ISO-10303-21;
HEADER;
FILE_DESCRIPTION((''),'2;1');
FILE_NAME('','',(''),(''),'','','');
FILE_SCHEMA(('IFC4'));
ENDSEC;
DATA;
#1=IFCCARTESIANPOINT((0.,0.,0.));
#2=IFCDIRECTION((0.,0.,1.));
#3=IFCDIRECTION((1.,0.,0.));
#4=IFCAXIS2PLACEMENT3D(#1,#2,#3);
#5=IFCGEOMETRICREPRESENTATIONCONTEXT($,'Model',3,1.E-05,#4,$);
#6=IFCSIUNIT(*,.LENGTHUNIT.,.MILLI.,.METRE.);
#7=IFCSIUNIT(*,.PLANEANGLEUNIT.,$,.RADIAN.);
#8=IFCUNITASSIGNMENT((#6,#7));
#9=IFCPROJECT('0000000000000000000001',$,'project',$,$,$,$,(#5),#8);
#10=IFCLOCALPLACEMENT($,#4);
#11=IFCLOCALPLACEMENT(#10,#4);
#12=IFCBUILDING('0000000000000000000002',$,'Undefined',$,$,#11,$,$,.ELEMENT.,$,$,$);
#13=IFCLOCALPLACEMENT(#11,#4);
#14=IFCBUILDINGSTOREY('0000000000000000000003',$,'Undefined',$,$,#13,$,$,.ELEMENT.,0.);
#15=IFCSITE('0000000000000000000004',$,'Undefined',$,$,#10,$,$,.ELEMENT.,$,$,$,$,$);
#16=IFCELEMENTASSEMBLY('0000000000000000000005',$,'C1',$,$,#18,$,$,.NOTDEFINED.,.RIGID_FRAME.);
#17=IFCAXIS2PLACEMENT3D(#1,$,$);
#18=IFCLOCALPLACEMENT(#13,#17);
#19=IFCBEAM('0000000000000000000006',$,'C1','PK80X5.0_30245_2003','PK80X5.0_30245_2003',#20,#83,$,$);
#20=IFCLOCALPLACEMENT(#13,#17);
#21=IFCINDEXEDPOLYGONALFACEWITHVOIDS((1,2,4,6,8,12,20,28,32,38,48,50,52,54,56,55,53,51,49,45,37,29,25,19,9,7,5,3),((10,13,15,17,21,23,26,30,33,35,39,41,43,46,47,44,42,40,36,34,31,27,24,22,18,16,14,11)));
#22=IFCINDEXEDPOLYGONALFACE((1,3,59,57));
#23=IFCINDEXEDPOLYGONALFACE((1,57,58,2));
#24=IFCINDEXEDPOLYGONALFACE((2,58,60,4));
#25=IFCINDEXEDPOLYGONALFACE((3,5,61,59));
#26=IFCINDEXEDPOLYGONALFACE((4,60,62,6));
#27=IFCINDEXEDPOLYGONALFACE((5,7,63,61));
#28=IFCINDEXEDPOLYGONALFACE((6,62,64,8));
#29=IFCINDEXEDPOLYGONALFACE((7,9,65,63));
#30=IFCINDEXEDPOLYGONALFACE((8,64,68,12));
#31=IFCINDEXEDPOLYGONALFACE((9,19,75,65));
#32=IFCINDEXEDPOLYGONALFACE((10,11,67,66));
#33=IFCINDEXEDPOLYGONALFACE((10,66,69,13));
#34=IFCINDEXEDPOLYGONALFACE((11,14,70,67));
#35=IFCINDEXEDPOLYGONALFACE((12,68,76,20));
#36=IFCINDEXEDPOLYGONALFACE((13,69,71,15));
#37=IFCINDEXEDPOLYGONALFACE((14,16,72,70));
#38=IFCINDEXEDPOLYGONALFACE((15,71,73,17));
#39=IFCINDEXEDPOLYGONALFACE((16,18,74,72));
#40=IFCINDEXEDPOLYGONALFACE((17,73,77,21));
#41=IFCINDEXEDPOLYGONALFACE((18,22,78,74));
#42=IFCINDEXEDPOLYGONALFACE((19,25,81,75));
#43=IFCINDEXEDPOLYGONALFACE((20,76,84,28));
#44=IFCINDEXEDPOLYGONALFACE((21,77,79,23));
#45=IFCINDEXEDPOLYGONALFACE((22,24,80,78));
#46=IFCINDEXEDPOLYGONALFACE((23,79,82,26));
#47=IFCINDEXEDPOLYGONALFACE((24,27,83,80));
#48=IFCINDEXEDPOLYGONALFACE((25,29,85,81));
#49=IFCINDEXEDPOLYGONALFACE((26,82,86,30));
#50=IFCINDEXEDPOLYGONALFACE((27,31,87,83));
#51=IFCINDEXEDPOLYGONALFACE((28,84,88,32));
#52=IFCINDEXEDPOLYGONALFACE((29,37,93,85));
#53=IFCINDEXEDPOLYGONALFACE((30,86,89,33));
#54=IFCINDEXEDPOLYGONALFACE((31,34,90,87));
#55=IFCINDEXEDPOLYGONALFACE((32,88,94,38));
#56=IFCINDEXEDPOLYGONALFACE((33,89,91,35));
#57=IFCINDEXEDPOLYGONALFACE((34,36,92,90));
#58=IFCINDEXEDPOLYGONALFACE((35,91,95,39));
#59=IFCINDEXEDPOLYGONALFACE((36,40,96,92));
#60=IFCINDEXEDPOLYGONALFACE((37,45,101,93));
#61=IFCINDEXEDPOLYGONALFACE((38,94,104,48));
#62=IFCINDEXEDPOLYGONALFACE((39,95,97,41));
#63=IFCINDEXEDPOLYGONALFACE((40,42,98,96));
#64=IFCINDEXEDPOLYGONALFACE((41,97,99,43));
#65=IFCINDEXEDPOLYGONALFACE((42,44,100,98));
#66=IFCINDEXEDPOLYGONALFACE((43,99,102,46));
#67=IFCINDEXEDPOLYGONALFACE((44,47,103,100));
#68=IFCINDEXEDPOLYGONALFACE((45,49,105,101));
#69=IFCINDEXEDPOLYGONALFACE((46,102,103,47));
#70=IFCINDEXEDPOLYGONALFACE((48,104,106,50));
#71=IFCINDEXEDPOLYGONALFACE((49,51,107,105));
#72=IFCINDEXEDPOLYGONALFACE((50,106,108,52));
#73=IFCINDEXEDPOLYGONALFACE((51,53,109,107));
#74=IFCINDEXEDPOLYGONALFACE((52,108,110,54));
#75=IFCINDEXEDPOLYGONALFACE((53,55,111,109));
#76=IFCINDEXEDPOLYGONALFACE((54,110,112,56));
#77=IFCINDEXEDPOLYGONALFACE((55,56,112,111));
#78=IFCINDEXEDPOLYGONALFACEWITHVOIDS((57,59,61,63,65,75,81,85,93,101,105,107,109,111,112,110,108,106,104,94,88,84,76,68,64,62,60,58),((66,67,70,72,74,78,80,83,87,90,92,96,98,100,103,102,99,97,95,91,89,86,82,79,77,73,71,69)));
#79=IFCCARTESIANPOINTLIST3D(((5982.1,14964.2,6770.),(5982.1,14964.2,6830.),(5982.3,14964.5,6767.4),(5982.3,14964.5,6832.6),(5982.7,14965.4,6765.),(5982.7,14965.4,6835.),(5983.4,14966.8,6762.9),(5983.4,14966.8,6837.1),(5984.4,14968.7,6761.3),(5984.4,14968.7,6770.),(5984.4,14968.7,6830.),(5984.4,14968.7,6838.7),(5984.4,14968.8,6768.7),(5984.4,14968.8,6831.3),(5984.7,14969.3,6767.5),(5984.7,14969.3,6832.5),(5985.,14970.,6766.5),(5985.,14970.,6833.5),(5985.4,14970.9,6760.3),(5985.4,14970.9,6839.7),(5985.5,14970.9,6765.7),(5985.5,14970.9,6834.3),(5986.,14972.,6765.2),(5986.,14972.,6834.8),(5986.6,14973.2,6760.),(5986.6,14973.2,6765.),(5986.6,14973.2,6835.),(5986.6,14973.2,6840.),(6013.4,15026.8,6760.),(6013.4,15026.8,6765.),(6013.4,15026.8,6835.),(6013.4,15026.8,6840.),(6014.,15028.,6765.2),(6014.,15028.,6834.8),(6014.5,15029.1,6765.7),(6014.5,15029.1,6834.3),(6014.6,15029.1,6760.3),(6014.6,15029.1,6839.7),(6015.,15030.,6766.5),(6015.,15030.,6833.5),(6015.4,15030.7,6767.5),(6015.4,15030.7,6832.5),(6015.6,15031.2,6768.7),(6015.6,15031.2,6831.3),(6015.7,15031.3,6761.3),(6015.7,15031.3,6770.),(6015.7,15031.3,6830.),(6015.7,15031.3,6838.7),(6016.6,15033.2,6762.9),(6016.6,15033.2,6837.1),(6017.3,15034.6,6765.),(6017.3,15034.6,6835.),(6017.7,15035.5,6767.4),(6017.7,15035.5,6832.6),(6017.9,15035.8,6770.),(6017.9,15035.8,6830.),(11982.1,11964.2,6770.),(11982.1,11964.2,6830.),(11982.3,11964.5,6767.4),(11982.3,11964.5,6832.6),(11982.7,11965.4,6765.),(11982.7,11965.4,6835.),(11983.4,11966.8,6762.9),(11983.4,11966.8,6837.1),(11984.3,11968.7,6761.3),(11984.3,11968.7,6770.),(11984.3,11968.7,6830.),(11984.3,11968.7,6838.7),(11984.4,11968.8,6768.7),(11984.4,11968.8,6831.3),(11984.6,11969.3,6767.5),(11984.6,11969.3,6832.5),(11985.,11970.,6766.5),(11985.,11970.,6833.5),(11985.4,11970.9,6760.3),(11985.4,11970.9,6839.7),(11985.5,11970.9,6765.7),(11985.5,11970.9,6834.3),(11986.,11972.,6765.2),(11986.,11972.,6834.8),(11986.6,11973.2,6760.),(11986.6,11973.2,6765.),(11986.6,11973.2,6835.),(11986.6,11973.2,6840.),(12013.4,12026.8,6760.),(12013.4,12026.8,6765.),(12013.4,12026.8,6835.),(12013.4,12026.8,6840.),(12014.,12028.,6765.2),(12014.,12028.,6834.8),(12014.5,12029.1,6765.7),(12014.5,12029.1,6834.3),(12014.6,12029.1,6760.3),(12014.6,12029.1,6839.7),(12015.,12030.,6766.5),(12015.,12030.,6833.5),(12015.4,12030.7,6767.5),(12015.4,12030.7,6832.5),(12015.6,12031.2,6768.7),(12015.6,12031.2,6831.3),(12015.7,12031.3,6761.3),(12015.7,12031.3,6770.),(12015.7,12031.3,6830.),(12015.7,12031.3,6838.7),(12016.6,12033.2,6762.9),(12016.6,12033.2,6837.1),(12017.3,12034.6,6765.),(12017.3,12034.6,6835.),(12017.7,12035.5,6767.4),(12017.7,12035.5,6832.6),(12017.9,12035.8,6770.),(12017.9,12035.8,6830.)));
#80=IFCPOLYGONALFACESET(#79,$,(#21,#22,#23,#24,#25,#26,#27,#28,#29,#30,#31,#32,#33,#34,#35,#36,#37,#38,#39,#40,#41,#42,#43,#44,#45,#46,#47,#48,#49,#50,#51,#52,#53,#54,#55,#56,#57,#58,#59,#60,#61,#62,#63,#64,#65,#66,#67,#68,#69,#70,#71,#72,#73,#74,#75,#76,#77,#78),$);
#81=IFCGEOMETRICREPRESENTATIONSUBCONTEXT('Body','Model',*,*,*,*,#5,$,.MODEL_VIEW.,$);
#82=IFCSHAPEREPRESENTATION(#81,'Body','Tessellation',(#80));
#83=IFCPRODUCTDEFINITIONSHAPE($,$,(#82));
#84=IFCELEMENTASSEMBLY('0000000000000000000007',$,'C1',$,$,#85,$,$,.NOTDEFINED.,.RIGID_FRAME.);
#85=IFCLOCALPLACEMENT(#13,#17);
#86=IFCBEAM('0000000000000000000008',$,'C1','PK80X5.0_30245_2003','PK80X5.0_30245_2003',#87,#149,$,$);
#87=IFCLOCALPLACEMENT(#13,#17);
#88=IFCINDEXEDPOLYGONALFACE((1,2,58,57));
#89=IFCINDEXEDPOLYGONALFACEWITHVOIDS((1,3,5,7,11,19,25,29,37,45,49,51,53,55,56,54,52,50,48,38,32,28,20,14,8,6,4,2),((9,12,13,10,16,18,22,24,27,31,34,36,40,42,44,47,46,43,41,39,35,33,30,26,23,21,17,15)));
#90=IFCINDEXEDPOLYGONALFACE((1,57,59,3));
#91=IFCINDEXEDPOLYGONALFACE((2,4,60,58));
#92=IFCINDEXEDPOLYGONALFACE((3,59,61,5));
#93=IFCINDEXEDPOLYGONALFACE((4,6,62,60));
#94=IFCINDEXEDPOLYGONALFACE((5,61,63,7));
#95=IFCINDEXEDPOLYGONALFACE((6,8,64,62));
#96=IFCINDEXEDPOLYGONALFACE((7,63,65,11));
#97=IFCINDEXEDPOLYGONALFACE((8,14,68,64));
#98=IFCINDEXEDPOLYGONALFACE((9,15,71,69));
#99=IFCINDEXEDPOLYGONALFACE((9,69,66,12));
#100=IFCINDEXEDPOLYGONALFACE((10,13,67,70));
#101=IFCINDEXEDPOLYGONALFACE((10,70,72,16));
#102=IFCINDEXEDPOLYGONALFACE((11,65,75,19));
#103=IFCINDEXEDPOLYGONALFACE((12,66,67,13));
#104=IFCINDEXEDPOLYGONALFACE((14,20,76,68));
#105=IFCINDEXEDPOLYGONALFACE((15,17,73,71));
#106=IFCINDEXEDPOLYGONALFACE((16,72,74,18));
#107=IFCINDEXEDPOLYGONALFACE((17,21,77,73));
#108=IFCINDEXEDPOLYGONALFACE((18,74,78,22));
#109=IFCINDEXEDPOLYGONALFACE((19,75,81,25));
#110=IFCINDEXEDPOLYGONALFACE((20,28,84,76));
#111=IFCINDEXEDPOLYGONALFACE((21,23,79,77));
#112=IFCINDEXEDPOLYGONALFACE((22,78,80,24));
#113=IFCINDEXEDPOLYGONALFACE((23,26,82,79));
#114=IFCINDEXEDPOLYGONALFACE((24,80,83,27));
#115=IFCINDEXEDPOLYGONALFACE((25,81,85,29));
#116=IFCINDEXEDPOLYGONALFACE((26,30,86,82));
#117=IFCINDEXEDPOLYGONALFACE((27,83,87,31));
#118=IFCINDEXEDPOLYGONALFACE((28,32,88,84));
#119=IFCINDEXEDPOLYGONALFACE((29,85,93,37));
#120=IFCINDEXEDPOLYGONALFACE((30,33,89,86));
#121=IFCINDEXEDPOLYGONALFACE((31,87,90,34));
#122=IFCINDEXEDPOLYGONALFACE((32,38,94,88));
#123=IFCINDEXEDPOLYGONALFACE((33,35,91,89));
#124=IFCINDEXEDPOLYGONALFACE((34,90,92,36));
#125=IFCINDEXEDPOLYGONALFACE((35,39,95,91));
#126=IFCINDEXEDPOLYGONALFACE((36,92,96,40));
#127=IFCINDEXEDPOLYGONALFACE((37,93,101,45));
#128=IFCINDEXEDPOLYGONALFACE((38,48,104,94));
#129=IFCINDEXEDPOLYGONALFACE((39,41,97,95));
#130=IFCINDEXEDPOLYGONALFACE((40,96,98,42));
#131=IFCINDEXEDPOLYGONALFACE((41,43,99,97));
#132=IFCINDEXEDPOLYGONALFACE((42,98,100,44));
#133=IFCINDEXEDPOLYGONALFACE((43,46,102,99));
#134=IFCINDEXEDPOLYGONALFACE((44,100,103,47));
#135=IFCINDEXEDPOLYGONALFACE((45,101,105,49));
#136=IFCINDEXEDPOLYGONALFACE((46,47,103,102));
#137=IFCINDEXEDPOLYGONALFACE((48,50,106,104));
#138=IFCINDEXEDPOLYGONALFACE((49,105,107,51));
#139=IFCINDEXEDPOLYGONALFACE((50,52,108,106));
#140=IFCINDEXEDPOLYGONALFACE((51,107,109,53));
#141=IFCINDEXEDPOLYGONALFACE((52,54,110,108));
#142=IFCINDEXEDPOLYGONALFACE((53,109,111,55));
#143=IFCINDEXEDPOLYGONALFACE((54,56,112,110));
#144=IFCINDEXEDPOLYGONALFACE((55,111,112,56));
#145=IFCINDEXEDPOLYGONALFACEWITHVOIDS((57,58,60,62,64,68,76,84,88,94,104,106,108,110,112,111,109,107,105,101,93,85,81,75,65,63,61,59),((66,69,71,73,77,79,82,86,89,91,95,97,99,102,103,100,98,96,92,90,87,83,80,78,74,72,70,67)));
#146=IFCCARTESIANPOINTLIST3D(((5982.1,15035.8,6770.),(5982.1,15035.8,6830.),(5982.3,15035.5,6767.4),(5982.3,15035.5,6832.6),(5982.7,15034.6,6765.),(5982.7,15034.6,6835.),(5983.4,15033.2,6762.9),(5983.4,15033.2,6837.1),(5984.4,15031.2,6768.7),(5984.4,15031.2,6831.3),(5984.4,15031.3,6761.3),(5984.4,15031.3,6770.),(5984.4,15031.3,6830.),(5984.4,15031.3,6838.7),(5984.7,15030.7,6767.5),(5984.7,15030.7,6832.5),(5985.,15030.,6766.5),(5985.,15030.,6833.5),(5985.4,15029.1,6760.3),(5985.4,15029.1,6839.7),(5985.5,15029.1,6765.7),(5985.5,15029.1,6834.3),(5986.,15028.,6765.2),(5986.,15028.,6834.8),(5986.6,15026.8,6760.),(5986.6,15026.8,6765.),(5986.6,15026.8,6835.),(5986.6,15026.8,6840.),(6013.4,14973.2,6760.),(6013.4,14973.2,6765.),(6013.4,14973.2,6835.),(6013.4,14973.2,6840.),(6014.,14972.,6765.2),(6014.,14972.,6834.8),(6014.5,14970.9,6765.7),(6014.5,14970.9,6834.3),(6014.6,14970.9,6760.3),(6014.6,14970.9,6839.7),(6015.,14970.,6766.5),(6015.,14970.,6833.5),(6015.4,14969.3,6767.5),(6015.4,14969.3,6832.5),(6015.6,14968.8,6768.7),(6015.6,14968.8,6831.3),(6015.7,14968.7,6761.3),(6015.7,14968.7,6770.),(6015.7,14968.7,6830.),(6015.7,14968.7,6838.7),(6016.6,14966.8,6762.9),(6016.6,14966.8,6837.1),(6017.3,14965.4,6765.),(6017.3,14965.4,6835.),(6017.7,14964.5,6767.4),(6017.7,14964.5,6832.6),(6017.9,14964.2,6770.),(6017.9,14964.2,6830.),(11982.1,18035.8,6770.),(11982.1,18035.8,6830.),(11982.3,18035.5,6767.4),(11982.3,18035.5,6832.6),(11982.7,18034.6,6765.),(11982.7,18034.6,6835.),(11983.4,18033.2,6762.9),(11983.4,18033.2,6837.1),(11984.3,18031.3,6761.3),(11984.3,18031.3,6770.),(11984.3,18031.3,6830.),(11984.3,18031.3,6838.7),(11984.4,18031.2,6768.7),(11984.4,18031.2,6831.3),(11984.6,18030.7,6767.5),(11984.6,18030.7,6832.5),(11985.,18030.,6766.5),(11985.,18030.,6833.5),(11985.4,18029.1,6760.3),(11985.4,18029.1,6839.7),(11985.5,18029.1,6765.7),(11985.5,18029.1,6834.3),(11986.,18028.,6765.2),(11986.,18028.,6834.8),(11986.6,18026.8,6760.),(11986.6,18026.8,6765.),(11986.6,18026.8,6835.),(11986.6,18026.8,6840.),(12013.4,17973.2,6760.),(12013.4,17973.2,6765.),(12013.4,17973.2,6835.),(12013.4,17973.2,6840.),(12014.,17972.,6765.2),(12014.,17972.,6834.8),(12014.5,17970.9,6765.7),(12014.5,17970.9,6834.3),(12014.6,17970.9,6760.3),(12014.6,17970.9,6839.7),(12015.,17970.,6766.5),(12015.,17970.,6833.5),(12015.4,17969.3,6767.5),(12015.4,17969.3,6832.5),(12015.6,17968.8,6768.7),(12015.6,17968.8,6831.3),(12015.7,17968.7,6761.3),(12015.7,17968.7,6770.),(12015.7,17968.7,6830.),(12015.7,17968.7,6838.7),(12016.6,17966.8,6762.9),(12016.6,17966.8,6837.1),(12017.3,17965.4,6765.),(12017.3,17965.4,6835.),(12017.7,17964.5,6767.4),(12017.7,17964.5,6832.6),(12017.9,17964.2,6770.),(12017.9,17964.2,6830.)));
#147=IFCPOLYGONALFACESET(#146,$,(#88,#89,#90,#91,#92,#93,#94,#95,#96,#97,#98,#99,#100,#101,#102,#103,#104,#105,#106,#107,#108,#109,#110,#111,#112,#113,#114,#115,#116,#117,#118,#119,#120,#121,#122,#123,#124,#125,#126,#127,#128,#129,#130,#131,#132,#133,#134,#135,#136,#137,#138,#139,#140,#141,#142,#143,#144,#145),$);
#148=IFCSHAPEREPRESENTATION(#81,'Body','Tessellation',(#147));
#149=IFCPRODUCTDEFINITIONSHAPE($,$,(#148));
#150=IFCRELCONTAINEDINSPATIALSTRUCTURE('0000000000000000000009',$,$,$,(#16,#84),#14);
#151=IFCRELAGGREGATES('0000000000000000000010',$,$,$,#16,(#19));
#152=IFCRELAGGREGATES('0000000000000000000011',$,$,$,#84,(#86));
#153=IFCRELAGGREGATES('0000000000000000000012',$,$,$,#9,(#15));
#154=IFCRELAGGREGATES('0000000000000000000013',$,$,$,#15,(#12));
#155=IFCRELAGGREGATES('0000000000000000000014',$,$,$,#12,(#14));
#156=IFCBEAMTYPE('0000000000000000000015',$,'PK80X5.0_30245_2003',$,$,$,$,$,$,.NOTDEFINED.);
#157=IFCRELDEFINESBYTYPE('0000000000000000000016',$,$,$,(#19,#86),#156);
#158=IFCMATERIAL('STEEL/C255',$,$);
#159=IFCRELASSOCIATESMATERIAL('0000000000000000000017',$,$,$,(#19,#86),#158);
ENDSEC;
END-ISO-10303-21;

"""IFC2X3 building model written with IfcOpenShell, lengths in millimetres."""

from ifc_helpers import new_model, si_unit, frame, origin_with_axes, origin_2d_with_axis, place, context, subcontext, project, spatial, hollow_rectangle, extrude, material, type_object, element, aggregate, save


model = new_model("IFC2X3")

# Units and contexts
model_context = context("Model", 3, precision=1e-05, world=origin_with_axes())
body_context = subcontext(model_context, "Body", "Model", "MODEL_VIEW")
ifc_project = project(units=[si_unit("LENGTHUNIT", "METRE", prefix="MILLI"), si_unit("PLANEANGLEUNIT", "RADIAN")], contexts=[model_context])

# Site, building, storey
site_placement = place(None, origin_with_axes())
site = spatial("IfcSite", under=ifc_project, at=site_placement, Name="Undefined", CompositionType="ELEMENT")
building_placement = place(site_placement, origin_with_axes())
building = spatial("IfcBuilding", under=site, at=building_placement, Name="Undefined", CompositionType="ELEMENT")
storey_placement = place(building_placement, origin_with_axes())
storey = spatial("IfcBuildingStorey", under=building, at=storey_placement, Name="Undefined", CompositionType="ELEMENT", Elevation=0.0)

# Element assemblies, beams
assembly_1_placement = place(storey_placement, origin_with_axes())
assembly_1 = element("IfcElementAssembly", 1, at=assembly_1_placement, inside=storey, Name="C1", AssemblyPlace="NOTDEFINED", PredefinedType="RIGID_FRAME")
ifc_material_1 = material(Name="STEEL/C255")
beam_type_1 = type_object("IfcBeamType", Name="PK80X5.0_30245_2003", PredefinedType="NOTDEFINED")
beam_1_placement = place(assembly_1_placement, frame((6000.0, 15000.0, 6800.0), z_axis=(0.0, 0.0, -1.0), x_axis=(0.894427, -0.447214, 0.0)))
beam_1 = element("IfcBeam", 2, at=beam_1_placement, type_object=beam_type_1, material=ifc_material_1, Name="C1", Description="PK80X5.0_30245_2003", ObjectType="PK80X5.0_30245_2003", context=body_context, shape_type="SweptSolid", body=[
    extrude(hollow_rectangle(XDim=80.0, YDim=80.0, WallThickness=5.0, InnerFilletRadius=5.0, OuterFilletRadius=10.0, at=origin_2d_with_axis()), frame((6708.2, 0.0, 0.0), z_axis=(-1.0, 0.0, 0.0), x_axis=(0.0, -1.0, 0.0)), (0.0, 0.0, 1.0), 6708.2),
])
aggregate(assembly_1, [beam_1])
assembly_2_placement = place(storey_placement, origin_with_axes())
assembly_2 = element("IfcElementAssembly", 3, at=assembly_2_placement, inside=storey, Name="C1", AssemblyPlace="NOTDEFINED", PredefinedType="RIGID_FRAME")
beam_2_placement = place(assembly_2_placement, frame((6000.0, 15000.0, 6800.0), z_axis=(0.0, 0.0, -1.0), x_axis=(0.894427, 0.447214, 0.0)))
beam_2 = element("IfcBeam", 4, at=beam_2_placement, type_object=beam_type_1, material=ifc_material_1, Name="C1", Description="PK80X5.0_30245_2003", ObjectType="PK80X5.0_30245_2003", context=body_context, shape_type="SweptSolid", body=[
    extrude(hollow_rectangle(XDim=80.0, YDim=80.0, WallThickness=5.0, InnerFilletRadius=5.0, OuterFilletRadius=10.0, at=origin_2d_with_axis()), frame((6708.2, 0.0, 0.0), z_axis=(-1.0, 0.0, 0.0), x_axis=(0.0, -1.0, 0.0)), (0.0, 0.0, 1.0), 6708.2),
])
aggregate(assembly_2, [beam_2])

save(model, "model.ifc")
